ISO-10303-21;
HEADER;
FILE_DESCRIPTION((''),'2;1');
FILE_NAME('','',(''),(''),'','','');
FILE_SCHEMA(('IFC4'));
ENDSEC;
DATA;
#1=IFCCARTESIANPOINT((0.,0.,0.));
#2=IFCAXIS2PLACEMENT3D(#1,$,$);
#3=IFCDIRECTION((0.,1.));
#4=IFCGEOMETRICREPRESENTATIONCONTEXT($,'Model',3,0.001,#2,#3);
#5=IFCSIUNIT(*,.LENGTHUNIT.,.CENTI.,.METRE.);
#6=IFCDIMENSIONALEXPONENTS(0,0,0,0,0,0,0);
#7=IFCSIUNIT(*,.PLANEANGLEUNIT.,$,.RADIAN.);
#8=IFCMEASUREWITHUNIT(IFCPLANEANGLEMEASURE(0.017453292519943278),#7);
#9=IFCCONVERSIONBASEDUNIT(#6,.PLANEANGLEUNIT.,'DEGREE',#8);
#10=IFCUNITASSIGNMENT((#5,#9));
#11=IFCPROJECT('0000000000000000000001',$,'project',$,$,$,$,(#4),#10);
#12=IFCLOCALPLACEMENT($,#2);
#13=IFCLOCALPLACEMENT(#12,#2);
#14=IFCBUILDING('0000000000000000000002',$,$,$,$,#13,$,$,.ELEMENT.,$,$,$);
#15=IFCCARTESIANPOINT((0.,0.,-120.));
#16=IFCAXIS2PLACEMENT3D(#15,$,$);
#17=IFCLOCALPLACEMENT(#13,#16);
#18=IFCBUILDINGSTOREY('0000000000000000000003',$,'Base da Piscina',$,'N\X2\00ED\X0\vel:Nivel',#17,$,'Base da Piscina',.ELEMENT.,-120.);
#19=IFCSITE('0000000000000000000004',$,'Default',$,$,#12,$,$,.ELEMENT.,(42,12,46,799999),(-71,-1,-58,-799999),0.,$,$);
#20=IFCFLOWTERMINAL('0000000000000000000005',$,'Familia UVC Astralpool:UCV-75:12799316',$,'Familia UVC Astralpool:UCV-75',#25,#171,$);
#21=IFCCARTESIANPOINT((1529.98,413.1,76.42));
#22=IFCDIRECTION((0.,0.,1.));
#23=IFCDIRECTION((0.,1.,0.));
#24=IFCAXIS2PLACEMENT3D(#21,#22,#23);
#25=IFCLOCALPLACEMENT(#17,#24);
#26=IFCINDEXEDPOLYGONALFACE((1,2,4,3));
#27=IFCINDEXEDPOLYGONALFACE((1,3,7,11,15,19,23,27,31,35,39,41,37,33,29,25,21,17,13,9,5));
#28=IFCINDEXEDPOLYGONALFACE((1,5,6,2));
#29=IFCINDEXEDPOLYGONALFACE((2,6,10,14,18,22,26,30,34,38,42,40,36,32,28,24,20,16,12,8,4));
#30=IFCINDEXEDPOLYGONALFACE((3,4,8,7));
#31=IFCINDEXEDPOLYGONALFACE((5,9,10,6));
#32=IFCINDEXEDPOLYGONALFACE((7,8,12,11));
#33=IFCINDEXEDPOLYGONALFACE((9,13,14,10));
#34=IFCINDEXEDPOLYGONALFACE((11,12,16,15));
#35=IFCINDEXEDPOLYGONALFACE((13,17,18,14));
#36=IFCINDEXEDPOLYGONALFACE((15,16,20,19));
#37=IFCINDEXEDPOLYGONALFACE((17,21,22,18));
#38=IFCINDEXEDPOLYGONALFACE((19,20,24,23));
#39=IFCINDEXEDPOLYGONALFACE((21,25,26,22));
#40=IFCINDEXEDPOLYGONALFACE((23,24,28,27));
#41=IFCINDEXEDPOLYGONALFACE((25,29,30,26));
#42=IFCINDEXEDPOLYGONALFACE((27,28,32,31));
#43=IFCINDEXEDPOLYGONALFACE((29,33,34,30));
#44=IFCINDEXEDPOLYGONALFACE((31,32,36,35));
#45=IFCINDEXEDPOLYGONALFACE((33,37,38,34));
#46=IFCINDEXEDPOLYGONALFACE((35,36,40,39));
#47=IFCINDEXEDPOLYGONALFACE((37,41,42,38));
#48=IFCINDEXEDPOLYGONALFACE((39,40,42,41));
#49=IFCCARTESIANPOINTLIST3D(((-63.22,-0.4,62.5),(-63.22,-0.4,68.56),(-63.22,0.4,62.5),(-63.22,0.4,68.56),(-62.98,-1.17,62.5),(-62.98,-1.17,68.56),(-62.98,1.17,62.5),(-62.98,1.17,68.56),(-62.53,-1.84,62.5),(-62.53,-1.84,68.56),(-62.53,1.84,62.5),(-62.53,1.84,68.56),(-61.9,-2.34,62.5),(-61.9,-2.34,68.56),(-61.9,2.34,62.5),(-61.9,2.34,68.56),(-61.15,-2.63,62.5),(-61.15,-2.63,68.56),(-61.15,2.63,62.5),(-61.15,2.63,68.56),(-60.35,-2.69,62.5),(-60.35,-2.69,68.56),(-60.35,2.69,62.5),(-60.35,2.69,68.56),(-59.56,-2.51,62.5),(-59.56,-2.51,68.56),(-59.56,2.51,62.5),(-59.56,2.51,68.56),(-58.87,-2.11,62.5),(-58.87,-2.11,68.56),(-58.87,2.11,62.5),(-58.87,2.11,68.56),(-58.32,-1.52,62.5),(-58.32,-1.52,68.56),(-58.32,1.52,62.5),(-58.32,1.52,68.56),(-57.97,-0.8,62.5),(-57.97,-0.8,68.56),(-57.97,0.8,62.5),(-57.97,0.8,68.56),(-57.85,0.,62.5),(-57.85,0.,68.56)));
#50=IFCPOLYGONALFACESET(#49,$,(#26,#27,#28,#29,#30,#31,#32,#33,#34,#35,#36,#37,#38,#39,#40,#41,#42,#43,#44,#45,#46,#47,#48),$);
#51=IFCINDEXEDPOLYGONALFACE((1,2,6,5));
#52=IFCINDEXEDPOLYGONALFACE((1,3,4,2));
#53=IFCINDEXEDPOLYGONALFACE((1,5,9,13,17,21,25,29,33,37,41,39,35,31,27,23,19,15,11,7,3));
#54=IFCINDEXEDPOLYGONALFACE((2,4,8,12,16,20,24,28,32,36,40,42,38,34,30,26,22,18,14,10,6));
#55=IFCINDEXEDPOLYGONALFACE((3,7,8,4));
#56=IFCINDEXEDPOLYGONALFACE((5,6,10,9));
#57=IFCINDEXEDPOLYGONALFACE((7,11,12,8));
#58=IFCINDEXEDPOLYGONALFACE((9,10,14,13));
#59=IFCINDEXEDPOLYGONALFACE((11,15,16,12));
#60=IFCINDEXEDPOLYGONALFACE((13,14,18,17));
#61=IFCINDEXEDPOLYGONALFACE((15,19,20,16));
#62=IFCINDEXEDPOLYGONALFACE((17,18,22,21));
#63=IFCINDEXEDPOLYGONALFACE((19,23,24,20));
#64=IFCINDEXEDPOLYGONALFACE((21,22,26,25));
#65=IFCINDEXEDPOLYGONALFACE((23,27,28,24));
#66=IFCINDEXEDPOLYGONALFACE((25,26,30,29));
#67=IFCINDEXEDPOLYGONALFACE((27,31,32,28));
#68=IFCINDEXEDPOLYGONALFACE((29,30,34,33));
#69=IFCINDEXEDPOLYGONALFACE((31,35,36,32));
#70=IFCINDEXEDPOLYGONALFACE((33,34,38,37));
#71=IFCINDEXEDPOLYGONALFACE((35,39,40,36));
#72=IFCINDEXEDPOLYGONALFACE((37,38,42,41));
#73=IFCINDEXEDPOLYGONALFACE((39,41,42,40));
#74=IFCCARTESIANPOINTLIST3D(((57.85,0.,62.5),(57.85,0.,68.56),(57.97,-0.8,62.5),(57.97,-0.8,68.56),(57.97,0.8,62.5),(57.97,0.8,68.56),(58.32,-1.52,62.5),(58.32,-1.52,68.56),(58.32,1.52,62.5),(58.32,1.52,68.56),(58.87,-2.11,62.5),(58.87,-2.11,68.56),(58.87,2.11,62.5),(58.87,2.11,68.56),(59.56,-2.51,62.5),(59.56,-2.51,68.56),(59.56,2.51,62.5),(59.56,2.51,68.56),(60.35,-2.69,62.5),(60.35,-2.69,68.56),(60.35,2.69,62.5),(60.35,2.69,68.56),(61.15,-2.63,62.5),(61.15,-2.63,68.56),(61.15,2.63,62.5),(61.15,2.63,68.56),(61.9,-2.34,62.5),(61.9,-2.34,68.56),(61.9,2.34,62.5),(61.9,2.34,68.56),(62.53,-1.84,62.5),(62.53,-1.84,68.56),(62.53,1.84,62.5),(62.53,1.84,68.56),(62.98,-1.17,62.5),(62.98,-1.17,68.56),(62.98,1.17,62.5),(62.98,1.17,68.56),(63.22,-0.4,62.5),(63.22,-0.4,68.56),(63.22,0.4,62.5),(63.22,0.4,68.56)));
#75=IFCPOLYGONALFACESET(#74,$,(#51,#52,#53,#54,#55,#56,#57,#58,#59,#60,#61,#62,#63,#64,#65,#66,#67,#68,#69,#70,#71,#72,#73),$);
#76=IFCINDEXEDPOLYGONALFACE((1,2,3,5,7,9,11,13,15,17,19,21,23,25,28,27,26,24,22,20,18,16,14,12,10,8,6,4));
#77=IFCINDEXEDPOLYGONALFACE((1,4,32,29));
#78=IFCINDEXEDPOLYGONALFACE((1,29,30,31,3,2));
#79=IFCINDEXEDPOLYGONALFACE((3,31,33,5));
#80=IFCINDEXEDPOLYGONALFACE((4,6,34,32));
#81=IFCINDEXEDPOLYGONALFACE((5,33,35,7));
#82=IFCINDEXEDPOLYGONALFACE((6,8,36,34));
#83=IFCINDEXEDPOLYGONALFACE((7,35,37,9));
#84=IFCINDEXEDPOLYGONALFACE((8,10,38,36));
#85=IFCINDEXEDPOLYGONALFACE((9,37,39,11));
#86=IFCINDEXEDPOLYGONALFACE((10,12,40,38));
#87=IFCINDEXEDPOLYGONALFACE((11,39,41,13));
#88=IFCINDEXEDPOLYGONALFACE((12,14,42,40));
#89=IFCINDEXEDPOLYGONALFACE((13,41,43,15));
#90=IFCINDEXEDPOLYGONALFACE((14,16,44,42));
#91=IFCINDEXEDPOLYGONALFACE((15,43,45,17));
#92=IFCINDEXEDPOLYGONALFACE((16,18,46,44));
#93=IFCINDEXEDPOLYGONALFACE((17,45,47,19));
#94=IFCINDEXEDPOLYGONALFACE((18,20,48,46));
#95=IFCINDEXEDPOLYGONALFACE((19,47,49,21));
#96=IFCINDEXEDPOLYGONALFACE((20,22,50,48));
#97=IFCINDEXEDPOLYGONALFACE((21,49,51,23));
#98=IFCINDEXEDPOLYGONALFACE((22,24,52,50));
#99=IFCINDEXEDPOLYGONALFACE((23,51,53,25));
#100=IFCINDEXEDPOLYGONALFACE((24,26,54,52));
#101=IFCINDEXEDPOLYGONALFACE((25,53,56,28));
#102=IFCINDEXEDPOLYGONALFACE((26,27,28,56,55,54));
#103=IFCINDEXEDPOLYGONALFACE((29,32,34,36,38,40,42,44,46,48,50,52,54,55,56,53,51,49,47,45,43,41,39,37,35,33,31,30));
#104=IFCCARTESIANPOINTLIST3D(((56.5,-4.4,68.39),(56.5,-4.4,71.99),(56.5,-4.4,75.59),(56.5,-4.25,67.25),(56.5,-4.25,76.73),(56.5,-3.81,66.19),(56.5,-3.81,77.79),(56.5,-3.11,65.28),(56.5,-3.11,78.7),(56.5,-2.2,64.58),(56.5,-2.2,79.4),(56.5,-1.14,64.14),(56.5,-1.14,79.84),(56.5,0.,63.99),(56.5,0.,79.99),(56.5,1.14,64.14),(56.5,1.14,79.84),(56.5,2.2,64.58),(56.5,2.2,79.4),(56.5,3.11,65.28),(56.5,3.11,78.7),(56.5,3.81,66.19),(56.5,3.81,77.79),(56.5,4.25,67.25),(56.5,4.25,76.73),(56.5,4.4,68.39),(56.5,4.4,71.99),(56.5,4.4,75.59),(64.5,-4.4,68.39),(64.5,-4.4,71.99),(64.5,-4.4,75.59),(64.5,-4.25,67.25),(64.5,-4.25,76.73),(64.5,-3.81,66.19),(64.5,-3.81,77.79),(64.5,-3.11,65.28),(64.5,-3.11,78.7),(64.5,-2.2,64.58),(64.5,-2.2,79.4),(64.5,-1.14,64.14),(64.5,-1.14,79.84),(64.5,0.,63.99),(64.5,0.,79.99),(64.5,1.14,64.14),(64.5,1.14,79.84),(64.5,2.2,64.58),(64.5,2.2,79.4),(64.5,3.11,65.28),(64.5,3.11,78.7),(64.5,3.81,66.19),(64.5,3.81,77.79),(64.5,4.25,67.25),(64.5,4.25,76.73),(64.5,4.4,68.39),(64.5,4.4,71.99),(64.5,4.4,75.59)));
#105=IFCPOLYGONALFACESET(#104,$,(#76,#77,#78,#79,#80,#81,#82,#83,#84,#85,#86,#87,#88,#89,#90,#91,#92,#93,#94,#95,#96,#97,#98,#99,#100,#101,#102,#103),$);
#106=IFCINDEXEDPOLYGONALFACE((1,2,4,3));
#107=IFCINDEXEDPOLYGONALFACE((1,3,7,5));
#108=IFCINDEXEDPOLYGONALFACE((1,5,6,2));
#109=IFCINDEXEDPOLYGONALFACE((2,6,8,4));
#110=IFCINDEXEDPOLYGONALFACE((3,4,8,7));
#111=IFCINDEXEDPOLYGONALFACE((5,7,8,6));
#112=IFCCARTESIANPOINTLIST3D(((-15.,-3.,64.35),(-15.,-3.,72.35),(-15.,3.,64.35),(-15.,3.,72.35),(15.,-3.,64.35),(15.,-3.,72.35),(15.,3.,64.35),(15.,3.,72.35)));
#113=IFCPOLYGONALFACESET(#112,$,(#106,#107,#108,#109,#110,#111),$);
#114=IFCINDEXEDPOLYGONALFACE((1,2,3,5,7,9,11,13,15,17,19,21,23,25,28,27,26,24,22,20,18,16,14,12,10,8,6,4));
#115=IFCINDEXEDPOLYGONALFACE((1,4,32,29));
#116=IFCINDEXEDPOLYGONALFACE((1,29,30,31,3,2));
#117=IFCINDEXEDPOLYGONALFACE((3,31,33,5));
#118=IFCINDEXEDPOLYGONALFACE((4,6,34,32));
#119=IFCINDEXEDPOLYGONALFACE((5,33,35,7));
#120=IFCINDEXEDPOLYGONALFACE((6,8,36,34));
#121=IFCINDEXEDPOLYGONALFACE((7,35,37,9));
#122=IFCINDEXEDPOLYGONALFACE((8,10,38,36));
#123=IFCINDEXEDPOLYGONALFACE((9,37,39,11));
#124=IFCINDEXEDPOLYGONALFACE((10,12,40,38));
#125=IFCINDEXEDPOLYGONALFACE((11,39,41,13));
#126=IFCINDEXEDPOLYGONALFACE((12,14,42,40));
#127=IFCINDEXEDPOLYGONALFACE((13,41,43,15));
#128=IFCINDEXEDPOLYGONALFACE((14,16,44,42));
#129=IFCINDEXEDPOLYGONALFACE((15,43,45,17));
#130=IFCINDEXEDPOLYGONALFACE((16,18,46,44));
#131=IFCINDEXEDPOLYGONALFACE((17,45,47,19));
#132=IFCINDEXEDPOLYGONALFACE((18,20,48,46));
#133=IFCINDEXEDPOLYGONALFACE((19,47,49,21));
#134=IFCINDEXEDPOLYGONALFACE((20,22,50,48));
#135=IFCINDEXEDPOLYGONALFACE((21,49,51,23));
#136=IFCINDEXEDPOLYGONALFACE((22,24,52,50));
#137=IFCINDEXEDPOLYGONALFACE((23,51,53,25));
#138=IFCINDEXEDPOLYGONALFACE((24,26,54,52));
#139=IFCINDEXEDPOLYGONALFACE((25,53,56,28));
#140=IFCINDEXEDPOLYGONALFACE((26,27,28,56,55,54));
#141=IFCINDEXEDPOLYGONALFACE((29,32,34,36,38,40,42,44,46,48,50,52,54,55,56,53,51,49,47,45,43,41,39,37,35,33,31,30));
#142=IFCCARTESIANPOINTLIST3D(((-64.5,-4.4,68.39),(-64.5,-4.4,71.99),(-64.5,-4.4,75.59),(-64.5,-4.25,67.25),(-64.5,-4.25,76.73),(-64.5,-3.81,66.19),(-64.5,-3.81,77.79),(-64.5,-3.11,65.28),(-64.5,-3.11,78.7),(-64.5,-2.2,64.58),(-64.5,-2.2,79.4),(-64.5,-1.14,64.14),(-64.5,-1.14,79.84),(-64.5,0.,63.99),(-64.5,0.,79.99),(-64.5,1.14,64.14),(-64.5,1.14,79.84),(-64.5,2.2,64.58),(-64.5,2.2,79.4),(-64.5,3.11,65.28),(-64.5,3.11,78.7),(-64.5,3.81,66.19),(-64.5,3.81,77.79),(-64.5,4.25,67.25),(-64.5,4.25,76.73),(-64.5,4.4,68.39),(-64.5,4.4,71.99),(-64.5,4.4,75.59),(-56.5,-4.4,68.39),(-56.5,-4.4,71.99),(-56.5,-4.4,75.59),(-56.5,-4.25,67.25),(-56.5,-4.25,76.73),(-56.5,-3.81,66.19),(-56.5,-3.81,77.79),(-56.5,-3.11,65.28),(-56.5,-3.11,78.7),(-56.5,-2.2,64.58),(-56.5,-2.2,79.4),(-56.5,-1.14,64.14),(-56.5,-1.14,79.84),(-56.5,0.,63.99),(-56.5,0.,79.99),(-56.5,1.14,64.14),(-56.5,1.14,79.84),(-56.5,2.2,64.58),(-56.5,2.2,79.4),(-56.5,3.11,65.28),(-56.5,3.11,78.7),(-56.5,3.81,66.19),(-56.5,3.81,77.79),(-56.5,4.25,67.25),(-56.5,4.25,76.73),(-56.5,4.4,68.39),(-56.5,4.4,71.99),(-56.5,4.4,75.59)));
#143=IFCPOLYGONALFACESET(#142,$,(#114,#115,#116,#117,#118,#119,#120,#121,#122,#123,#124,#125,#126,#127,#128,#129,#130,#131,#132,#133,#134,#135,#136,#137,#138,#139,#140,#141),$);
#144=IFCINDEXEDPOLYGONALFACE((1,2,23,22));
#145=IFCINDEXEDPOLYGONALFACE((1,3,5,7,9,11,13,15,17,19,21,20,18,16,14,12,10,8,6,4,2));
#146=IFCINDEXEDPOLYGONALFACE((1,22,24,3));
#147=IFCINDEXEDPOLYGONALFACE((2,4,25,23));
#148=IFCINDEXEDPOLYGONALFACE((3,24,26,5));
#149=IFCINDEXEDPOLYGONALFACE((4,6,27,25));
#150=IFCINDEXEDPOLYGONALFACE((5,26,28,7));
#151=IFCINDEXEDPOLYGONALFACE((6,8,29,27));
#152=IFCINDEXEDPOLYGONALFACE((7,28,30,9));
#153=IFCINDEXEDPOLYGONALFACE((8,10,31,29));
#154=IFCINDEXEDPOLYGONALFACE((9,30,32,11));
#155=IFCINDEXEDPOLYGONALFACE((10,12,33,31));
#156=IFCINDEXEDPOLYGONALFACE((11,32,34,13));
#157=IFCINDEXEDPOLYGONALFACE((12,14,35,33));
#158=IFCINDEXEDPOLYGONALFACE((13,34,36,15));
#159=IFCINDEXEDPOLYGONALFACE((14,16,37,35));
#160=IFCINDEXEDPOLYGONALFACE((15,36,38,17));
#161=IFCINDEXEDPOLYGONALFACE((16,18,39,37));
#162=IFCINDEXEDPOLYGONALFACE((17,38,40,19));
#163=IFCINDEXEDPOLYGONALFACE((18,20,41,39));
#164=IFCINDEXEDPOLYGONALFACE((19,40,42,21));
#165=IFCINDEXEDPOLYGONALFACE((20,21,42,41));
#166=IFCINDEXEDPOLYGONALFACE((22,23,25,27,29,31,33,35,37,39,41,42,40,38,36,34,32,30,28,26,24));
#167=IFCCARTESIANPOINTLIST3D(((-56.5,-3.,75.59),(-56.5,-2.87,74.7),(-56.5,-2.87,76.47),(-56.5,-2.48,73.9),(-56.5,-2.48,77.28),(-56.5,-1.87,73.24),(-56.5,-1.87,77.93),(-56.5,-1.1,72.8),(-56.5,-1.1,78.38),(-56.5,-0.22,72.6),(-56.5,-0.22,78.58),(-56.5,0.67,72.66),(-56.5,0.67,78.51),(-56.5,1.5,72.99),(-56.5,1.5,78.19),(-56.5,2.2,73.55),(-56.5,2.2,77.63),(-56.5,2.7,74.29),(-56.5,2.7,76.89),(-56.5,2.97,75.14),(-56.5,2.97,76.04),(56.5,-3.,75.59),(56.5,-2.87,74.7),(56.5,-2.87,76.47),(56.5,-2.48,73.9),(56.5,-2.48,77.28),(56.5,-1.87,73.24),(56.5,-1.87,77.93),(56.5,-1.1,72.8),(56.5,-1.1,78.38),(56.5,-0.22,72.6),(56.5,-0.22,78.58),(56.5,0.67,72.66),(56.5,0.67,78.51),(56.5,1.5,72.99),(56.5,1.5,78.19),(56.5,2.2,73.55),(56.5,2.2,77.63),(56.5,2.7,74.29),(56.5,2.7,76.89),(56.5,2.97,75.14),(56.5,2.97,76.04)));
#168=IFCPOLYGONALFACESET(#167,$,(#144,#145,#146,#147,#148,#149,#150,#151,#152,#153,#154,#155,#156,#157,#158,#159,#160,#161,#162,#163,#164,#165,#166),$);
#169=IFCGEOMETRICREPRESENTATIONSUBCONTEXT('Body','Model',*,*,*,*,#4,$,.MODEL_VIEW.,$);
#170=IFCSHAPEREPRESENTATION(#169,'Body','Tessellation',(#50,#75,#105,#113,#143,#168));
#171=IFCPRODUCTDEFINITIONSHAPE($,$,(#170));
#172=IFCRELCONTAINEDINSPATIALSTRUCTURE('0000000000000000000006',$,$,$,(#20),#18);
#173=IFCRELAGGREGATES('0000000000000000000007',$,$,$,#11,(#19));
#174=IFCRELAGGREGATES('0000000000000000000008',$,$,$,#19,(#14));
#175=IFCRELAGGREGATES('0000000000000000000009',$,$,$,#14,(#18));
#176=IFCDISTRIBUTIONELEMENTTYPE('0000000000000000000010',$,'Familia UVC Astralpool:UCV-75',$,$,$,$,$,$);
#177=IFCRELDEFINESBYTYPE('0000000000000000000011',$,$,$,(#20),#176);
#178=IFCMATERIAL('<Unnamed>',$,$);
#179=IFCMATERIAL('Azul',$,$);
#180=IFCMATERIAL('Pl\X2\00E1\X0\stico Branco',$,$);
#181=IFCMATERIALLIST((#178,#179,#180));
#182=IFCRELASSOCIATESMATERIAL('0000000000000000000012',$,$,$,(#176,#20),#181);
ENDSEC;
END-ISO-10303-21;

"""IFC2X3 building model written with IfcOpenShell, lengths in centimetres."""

from ifc_helpers import new_model, entity, si_unit, converted_unit, direction, frame, frame_2d, origin, origin_2d_with_axis, place, context, subcontext, project, spatial, polyline, circle_curve, parameter, trimmed, segment, composite_curve, rectangle, circle, outline, extrude, source, transform, mapped, material, material_list, type_object, type_shapes, element, save


model = new_model("IFC2X3")

# Units and contexts
model_context = context("Model", 3, precision=0.001, world=origin(), true_north=direction((0.0, 1.0)))
body_context = subcontext(model_context, "Body", "Model", "MODEL_VIEW")
ifc_project = project(units=[si_unit("LENGTHUNIT", "METRE", prefix="CENTI"), converted_unit("PLANEANGLEUNIT", "DEGREE", entity("IfcPlaneAngleMeasure", 0.017453292519943278), si_unit("PLANEANGLEUNIT", "RADIAN"), dimensions=[0, 0, 0, 0, 0, 0, 0])], contexts=[model_context])

# Site, building, storey
site_placement = place(None, origin())
site = spatial("IfcSite", under=ifc_project, at=site_placement, Name="Default", CompositionType="ELEMENT", RefLatitude=(42, 12, 46, 799999), RefLongitude=(-71, -1, -58, -799999), RefElevation=0.0)
building_placement = place(site_placement, origin())
building = spatial("IfcBuilding", under=site, at=building_placement, CompositionType="ELEMENT")
storey_placement = place(building_placement, frame((0.0, 0.0, -120.0)))
storey = spatial("IfcBuildingStorey", under=building, at=storey_placement, Name="Base da Piscina", ObjectType="Nível:Nivel", LongName="Base da Piscina", CompositionType="ELEMENT", Elevation=-120.0)

# Flow terminal
ifc_material_1 = material(Name="<Unnamed>")
ifc_material_2 = material(Name="Azul")
ifc_material_3 = material(Name="Plástico Branco")
ifc_material_list = material_list([ifc_material_1, ifc_material_2, ifc_material_3])
distribution_element_type = type_object("IfcDistributionElementType", Name="Familia UVC Astralpool:UCV-75", material=ifc_material_list)
shared_shape_1 = source(origin(), body_context, "Body", "SweptSolid", [
    extrude(circle(Radius=2.7, at=frame_2d((0.0, 0.0), x_axis=(1.0, 0.0))), frame((-60.55, 0.0, 62.5)), (0.0, 0.0, 1.0), 6.06),
    extrude(circle(Radius=2.7, at=frame_2d((0.0, 0.0), x_axis=(1.0, 0.0))), frame((60.55, 0.0, 62.5), z_axis=(0.0, 0.0, 1.0), x_axis=(-1.0, 0.0, 0.0)), (0.0, 0.0, 1.0), 6.06),
    extrude(outline(composite_curve([segment(trimmed(circle_curve(frame_2d((0.0, -3.6), x_axis=(1.0, 0.0)), 4.4), [parameter(180.0)], [parameter(270.0)], True, "PARAMETER"), True, "CONTINUOUS"), segment(trimmed(circle_curve(frame_2d((0.0, -3.6), x_axis=(1.0, 0.0)), 4.4), [parameter(270.0)], [parameter(0.0)], True, "PARAMETER"), True, "CONTINUOUS"), segment(polyline([(4.4, -3.6), (4.4, 0.0)]), True, "CONTINUOUS"), segment(polyline([(4.4, 0.0), (4.4, 3.6)]), True, "CONTINUOUS"), segment(trimmed(circle_curve(frame_2d((0.0, 3.6), x_axis=(1.0, 0.0)), 4.4), [parameter(360.0)], [parameter(90.0)], True, "PARAMETER"), True, "CONTINUOUS"), segment(trimmed(circle_curve(frame_2d((0.0, 3.6), x_axis=(1.0, 0.0)), 4.4), [parameter(90.0)], [parameter(180.0)], True, "PARAMETER"), True, "CONTINUOUS"), segment(polyline([(-4.4, 3.6), (-4.4, 0.0)]), True, "CONTINUOUS"), segment(polyline([(-4.4, 0.0), (-4.4, -3.6)]), True, "CONTINUOUS")], self_intersect=False)), frame((56.5, 0.0, 71.99), z_axis=(1.0, 0.0, 0.0), x_axis=(0.0, -1.0, 0.0)), (0.0, 0.0, 1.0), 8.0),
    extrude(rectangle(XDim=6.0, YDim=30.0, at=origin_2d_with_axis()), frame((0.0, 0.0, 64.35), z_axis=(0.0, 0.0, 1.0), x_axis=(0.0, 1.0, 0.0)), (0.0, 0.0, 1.0), 8.0),
    extrude(outline(composite_curve([segment(trimmed(circle_curve(frame_2d((0.0, -3.6), x_axis=(1.0, 0.0)), 4.4), [parameter(180.0)], [parameter(270.0)], True, "PARAMETER"), True, "CONTINUOUS"), segment(trimmed(circle_curve(frame_2d((0.0, -3.6), x_axis=(1.0, 0.0)), 4.4), [parameter(270.0)], [parameter(0.0)], True, "PARAMETER"), True, "CONTINUOUS"), segment(polyline([(4.4, -3.6), (4.4, 0.0)]), True, "CONTINUOUS"), segment(polyline([(4.4, 0.0), (4.4, 3.6)]), True, "CONTINUOUS"), segment(trimmed(circle_curve(frame_2d((0.0, 3.6), x_axis=(1.0, 0.0)), 4.4), [parameter(0.0)], [parameter(90.0)], True, "PARAMETER"), True, "CONTINUOUS"), segment(trimmed(circle_curve(frame_2d((0.0, 3.6), x_axis=(1.0, 0.0)), 4.4), [parameter(90.0)], [parameter(180.0)], True, "PARAMETER"), True, "CONTINUOUS"), segment(polyline([(-4.4, 3.6), (-4.4, 0.0)]), True, "CONTINUOUS"), segment(polyline([(-4.4, 0.0), (-4.4, -3.6)]), True, "CONTINUOUS")], self_intersect=False)), frame((-64.5, 0.0, 71.99), z_axis=(1.0, 0.0, 0.0), x_axis=(0.0, -1.0, 0.0)), (0.0, 0.0, 1.0), 8.0),
    extrude(circle(Radius=3.0, at=frame_2d((0.0, 0.0), x_axis=(1.0, 0.0))), frame((-56.5, 0.0, 75.59), z_axis=(1.0, 0.0, 0.0), x_axis=(0.0, -1.0, 0.0)), (0.0, 0.0, 1.0), 113.0),
])
type_shapes(distribution_element_type, [shared_shape_1])
flow_terminal_placement = place(storey_placement, frame((1529.98, 413.1, 76.42), z_axis=(0.0, 0.0, 1.0), x_axis=(0.0, 1.0, 0.0)))
element("IfcFlowTerminal", 1, at=flow_terminal_placement, inside=storey, type_object=distribution_element_type, material=ifc_material_list, Name="Familia UVC Astralpool:UCV-75:12799316", ObjectType="Familia UVC Astralpool:UCV-75", context=body_context, shape_type="MappedRepresentation", body=[
    mapped(shared_shape_1, transform((0.0, 0.0, 0.0), scale=1.0)),
])

save(model, "model.ifc")
